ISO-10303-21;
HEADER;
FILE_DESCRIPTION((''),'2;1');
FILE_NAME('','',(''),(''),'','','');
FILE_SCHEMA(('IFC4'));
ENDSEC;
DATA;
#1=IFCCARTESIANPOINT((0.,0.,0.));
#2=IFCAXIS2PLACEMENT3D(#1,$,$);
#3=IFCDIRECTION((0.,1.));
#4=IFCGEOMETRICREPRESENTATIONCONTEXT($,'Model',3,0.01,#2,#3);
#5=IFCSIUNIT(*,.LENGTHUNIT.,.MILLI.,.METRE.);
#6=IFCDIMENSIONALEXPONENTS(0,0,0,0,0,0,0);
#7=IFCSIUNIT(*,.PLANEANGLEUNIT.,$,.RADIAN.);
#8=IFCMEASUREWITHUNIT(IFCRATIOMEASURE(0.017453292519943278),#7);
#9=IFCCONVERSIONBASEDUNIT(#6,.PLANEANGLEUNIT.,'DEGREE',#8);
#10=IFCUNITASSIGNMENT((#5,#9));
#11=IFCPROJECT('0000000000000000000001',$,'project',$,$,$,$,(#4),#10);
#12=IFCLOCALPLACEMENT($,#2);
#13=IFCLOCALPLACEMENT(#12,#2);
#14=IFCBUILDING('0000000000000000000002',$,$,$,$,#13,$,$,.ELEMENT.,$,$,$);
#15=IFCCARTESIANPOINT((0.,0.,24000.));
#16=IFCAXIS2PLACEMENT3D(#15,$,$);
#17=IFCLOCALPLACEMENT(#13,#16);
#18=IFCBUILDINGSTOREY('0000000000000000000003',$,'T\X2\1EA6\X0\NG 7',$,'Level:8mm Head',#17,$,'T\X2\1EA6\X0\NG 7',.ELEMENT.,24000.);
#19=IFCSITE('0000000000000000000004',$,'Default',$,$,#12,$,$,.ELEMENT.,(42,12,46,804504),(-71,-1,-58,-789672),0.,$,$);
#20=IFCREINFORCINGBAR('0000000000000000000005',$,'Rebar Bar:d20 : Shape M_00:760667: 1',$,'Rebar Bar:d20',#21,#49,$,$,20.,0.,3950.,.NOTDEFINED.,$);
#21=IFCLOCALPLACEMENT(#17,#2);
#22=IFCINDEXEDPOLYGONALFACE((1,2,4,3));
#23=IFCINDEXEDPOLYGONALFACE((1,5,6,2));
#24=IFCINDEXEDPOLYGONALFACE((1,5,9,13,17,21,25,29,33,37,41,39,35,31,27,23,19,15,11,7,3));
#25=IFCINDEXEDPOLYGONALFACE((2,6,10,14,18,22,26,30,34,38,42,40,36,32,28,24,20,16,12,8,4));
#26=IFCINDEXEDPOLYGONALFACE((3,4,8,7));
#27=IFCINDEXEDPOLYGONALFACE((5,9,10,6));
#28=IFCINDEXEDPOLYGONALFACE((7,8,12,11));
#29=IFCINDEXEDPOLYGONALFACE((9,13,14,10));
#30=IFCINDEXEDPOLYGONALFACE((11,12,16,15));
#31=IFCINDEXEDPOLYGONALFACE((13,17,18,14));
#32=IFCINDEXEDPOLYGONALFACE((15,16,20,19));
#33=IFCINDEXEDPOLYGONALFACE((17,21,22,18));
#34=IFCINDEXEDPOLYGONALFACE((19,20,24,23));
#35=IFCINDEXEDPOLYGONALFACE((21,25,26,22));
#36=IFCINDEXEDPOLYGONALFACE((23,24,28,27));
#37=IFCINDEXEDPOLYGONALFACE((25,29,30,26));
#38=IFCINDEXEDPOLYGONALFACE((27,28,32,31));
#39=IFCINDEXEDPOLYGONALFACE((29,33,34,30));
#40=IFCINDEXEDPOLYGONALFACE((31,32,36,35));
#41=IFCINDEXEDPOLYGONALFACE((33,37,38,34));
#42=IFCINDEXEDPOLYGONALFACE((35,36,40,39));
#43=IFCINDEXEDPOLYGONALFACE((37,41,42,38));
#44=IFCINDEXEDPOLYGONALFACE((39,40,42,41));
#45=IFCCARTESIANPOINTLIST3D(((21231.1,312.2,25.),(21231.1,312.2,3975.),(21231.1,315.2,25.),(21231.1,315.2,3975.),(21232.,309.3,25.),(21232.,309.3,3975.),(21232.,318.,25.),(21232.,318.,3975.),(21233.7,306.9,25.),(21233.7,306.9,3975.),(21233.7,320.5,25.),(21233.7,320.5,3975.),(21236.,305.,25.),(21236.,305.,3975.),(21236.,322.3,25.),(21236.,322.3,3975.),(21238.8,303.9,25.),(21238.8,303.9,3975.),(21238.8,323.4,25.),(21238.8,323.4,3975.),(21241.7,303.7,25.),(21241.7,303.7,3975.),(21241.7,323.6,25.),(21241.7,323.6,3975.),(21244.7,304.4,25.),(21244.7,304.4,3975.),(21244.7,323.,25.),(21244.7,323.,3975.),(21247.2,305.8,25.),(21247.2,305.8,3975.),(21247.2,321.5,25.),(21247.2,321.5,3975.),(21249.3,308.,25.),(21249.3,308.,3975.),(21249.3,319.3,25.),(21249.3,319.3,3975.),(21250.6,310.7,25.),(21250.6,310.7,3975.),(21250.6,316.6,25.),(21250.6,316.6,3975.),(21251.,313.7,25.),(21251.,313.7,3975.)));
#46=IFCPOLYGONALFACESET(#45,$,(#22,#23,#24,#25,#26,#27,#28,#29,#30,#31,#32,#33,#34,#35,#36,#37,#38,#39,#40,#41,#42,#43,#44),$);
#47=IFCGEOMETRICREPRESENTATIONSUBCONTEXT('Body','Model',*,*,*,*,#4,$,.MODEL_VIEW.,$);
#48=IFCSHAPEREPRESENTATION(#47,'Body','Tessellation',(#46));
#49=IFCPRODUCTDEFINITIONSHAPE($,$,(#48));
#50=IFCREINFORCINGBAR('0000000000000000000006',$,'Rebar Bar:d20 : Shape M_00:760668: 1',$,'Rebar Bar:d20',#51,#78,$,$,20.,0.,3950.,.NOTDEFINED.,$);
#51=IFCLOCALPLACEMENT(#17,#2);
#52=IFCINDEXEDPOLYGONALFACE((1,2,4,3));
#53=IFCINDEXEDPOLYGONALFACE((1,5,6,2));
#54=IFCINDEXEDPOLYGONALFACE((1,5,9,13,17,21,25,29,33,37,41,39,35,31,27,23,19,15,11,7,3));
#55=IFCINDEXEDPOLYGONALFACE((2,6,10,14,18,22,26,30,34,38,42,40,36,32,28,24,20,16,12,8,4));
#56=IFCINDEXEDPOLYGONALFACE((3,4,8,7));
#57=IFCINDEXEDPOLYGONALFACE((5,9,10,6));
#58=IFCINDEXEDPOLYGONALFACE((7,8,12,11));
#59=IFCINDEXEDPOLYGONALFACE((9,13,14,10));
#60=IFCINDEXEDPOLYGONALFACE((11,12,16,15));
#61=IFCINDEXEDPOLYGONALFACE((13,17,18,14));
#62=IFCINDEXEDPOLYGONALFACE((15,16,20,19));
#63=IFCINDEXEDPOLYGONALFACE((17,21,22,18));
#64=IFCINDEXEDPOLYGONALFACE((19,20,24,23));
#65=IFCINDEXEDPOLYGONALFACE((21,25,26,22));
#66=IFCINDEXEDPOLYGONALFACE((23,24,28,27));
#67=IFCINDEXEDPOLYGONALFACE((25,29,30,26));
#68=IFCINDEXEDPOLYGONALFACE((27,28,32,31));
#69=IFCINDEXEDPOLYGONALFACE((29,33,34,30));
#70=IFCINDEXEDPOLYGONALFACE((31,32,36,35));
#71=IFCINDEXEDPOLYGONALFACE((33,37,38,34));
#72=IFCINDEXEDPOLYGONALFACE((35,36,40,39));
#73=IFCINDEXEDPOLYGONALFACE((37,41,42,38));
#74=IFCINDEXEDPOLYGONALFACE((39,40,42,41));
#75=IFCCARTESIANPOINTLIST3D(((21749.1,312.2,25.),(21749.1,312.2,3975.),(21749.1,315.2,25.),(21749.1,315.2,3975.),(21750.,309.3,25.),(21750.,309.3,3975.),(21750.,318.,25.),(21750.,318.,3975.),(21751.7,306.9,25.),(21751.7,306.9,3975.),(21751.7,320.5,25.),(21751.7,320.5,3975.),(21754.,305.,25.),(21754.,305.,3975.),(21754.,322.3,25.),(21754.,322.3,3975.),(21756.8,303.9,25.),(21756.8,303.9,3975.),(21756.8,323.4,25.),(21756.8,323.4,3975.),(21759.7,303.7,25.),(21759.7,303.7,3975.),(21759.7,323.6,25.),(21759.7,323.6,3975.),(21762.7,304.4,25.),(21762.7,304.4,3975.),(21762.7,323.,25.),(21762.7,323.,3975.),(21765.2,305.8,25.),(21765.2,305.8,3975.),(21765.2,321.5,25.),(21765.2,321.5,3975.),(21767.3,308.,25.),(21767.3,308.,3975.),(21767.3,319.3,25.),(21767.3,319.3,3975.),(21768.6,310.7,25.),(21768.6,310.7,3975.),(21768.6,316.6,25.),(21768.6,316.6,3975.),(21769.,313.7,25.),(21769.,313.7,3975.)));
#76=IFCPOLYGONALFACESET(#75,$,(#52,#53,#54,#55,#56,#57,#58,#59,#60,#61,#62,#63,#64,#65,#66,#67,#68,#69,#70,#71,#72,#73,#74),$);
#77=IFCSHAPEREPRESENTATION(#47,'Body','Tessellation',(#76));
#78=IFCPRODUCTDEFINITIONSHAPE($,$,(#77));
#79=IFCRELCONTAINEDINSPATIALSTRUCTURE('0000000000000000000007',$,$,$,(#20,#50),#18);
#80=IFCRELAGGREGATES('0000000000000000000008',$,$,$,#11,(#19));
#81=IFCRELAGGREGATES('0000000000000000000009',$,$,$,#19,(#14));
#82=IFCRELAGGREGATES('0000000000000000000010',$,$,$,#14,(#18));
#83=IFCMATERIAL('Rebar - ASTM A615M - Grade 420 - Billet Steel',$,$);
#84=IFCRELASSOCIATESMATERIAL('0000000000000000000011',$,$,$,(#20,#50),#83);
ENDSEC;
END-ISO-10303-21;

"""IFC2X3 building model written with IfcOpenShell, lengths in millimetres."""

from ifc_helpers import new_model, entity, si_unit, converted_unit, direction, frame, origin, place, context, subcontext, project, spatial, material, element, save


model = new_model("IFC2X3")

# Units and contexts
model_context = context("Model", 3, precision=0.01, world=origin(), true_north=direction((0.0, 1.0)))
body_context = subcontext(model_context, "Body", "Model", "MODEL_VIEW")
ifc_project = project(units=[si_unit("LENGTHUNIT", "METRE", prefix="MILLI"), converted_unit("PLANEANGLEUNIT", "DEGREE", entity("IfcRatioMeasure", 0.017453292519943278), si_unit("PLANEANGLEUNIT", "RADIAN"), dimensions=[0, 0, 0, 0, 0, 0, 0])], contexts=[model_context])

# Site, building, storey
site_placement = place(None, origin())
site = spatial("IfcSite", under=ifc_project, at=site_placement, Name="Default", CompositionType="ELEMENT", RefLatitude=(42, 12, 46, 804504), RefLongitude=(-71, -1, -58, -789672), RefElevation=0.0)
building_placement = place(site_placement, origin())
building = spatial("IfcBuilding", under=site, at=building_placement, CompositionType="ELEMENT")
storey_placement = place(building_placement, frame((0.0, 0.0, 24000.0)))
storey = spatial("IfcBuildingStorey", under=building, at=storey_placement, Name="TẦNG 7", ObjectType="Level:8mm Head", LongName="TẦNG 7", CompositionType="ELEMENT", Elevation=24000.0)

# Reinforcing bars
ifc_material = material(Name="Rebar - ASTM A615M - Grade 420 - Billet Steel")
reinforcing_bar_1_placement = place(storey_placement, origin())
element("IfcReinforcingBar", 1, at=reinforcing_bar_1_placement, inside=storey, material=ifc_material, Name="Rebar Bar:d20 : Shape M_00:760667: 1", ObjectType="Rebar Bar:d20", BarLength=3950.0, BarRole="NOTDEFINED", CrossSectionArea=0.0, NominalDiameter=20.0, context=body_context, shape_type="AdvancedSweptSolid", body=[
    entity("IfcSweptDiskSolid", entity("IfcCompositeCurve", [entity("IfcCompositeCurveSegment", "CONTINUOUS", True, entity("IfcPolyline", [entity("IfcCartesianPoint", [21241.0, 313.7, 25.0]), entity("IfcCartesianPoint", [21241.0, 313.7, 3975.0])]))], False), 10.0, None, 0.0, 1.0),
])
reinforcing_bar_2_placement = place(storey_placement, origin())
element("IfcReinforcingBar", 2, at=reinforcing_bar_2_placement, inside=storey, material=ifc_material, Name="Rebar Bar:d20 : Shape M_00:760668: 1", ObjectType="Rebar Bar:d20", BarLength=3950.0, BarRole="NOTDEFINED", CrossSectionArea=0.0, NominalDiameter=20.0, context=body_context, shape_type="AdvancedSweptSolid", body=[
    entity("IfcSweptDiskSolid", entity("IfcCompositeCurve", [entity("IfcCompositeCurveSegment", "CONTINUOUS", True, entity("IfcPolyline", [entity("IfcCartesianPoint", [21759.0, 313.7, 25.0]), entity("IfcCartesianPoint", [21759.0, 313.7, 3975.0])]))], False), 10.0, None, 0.0, 1.0),
])

save(model, "model.ifc")
